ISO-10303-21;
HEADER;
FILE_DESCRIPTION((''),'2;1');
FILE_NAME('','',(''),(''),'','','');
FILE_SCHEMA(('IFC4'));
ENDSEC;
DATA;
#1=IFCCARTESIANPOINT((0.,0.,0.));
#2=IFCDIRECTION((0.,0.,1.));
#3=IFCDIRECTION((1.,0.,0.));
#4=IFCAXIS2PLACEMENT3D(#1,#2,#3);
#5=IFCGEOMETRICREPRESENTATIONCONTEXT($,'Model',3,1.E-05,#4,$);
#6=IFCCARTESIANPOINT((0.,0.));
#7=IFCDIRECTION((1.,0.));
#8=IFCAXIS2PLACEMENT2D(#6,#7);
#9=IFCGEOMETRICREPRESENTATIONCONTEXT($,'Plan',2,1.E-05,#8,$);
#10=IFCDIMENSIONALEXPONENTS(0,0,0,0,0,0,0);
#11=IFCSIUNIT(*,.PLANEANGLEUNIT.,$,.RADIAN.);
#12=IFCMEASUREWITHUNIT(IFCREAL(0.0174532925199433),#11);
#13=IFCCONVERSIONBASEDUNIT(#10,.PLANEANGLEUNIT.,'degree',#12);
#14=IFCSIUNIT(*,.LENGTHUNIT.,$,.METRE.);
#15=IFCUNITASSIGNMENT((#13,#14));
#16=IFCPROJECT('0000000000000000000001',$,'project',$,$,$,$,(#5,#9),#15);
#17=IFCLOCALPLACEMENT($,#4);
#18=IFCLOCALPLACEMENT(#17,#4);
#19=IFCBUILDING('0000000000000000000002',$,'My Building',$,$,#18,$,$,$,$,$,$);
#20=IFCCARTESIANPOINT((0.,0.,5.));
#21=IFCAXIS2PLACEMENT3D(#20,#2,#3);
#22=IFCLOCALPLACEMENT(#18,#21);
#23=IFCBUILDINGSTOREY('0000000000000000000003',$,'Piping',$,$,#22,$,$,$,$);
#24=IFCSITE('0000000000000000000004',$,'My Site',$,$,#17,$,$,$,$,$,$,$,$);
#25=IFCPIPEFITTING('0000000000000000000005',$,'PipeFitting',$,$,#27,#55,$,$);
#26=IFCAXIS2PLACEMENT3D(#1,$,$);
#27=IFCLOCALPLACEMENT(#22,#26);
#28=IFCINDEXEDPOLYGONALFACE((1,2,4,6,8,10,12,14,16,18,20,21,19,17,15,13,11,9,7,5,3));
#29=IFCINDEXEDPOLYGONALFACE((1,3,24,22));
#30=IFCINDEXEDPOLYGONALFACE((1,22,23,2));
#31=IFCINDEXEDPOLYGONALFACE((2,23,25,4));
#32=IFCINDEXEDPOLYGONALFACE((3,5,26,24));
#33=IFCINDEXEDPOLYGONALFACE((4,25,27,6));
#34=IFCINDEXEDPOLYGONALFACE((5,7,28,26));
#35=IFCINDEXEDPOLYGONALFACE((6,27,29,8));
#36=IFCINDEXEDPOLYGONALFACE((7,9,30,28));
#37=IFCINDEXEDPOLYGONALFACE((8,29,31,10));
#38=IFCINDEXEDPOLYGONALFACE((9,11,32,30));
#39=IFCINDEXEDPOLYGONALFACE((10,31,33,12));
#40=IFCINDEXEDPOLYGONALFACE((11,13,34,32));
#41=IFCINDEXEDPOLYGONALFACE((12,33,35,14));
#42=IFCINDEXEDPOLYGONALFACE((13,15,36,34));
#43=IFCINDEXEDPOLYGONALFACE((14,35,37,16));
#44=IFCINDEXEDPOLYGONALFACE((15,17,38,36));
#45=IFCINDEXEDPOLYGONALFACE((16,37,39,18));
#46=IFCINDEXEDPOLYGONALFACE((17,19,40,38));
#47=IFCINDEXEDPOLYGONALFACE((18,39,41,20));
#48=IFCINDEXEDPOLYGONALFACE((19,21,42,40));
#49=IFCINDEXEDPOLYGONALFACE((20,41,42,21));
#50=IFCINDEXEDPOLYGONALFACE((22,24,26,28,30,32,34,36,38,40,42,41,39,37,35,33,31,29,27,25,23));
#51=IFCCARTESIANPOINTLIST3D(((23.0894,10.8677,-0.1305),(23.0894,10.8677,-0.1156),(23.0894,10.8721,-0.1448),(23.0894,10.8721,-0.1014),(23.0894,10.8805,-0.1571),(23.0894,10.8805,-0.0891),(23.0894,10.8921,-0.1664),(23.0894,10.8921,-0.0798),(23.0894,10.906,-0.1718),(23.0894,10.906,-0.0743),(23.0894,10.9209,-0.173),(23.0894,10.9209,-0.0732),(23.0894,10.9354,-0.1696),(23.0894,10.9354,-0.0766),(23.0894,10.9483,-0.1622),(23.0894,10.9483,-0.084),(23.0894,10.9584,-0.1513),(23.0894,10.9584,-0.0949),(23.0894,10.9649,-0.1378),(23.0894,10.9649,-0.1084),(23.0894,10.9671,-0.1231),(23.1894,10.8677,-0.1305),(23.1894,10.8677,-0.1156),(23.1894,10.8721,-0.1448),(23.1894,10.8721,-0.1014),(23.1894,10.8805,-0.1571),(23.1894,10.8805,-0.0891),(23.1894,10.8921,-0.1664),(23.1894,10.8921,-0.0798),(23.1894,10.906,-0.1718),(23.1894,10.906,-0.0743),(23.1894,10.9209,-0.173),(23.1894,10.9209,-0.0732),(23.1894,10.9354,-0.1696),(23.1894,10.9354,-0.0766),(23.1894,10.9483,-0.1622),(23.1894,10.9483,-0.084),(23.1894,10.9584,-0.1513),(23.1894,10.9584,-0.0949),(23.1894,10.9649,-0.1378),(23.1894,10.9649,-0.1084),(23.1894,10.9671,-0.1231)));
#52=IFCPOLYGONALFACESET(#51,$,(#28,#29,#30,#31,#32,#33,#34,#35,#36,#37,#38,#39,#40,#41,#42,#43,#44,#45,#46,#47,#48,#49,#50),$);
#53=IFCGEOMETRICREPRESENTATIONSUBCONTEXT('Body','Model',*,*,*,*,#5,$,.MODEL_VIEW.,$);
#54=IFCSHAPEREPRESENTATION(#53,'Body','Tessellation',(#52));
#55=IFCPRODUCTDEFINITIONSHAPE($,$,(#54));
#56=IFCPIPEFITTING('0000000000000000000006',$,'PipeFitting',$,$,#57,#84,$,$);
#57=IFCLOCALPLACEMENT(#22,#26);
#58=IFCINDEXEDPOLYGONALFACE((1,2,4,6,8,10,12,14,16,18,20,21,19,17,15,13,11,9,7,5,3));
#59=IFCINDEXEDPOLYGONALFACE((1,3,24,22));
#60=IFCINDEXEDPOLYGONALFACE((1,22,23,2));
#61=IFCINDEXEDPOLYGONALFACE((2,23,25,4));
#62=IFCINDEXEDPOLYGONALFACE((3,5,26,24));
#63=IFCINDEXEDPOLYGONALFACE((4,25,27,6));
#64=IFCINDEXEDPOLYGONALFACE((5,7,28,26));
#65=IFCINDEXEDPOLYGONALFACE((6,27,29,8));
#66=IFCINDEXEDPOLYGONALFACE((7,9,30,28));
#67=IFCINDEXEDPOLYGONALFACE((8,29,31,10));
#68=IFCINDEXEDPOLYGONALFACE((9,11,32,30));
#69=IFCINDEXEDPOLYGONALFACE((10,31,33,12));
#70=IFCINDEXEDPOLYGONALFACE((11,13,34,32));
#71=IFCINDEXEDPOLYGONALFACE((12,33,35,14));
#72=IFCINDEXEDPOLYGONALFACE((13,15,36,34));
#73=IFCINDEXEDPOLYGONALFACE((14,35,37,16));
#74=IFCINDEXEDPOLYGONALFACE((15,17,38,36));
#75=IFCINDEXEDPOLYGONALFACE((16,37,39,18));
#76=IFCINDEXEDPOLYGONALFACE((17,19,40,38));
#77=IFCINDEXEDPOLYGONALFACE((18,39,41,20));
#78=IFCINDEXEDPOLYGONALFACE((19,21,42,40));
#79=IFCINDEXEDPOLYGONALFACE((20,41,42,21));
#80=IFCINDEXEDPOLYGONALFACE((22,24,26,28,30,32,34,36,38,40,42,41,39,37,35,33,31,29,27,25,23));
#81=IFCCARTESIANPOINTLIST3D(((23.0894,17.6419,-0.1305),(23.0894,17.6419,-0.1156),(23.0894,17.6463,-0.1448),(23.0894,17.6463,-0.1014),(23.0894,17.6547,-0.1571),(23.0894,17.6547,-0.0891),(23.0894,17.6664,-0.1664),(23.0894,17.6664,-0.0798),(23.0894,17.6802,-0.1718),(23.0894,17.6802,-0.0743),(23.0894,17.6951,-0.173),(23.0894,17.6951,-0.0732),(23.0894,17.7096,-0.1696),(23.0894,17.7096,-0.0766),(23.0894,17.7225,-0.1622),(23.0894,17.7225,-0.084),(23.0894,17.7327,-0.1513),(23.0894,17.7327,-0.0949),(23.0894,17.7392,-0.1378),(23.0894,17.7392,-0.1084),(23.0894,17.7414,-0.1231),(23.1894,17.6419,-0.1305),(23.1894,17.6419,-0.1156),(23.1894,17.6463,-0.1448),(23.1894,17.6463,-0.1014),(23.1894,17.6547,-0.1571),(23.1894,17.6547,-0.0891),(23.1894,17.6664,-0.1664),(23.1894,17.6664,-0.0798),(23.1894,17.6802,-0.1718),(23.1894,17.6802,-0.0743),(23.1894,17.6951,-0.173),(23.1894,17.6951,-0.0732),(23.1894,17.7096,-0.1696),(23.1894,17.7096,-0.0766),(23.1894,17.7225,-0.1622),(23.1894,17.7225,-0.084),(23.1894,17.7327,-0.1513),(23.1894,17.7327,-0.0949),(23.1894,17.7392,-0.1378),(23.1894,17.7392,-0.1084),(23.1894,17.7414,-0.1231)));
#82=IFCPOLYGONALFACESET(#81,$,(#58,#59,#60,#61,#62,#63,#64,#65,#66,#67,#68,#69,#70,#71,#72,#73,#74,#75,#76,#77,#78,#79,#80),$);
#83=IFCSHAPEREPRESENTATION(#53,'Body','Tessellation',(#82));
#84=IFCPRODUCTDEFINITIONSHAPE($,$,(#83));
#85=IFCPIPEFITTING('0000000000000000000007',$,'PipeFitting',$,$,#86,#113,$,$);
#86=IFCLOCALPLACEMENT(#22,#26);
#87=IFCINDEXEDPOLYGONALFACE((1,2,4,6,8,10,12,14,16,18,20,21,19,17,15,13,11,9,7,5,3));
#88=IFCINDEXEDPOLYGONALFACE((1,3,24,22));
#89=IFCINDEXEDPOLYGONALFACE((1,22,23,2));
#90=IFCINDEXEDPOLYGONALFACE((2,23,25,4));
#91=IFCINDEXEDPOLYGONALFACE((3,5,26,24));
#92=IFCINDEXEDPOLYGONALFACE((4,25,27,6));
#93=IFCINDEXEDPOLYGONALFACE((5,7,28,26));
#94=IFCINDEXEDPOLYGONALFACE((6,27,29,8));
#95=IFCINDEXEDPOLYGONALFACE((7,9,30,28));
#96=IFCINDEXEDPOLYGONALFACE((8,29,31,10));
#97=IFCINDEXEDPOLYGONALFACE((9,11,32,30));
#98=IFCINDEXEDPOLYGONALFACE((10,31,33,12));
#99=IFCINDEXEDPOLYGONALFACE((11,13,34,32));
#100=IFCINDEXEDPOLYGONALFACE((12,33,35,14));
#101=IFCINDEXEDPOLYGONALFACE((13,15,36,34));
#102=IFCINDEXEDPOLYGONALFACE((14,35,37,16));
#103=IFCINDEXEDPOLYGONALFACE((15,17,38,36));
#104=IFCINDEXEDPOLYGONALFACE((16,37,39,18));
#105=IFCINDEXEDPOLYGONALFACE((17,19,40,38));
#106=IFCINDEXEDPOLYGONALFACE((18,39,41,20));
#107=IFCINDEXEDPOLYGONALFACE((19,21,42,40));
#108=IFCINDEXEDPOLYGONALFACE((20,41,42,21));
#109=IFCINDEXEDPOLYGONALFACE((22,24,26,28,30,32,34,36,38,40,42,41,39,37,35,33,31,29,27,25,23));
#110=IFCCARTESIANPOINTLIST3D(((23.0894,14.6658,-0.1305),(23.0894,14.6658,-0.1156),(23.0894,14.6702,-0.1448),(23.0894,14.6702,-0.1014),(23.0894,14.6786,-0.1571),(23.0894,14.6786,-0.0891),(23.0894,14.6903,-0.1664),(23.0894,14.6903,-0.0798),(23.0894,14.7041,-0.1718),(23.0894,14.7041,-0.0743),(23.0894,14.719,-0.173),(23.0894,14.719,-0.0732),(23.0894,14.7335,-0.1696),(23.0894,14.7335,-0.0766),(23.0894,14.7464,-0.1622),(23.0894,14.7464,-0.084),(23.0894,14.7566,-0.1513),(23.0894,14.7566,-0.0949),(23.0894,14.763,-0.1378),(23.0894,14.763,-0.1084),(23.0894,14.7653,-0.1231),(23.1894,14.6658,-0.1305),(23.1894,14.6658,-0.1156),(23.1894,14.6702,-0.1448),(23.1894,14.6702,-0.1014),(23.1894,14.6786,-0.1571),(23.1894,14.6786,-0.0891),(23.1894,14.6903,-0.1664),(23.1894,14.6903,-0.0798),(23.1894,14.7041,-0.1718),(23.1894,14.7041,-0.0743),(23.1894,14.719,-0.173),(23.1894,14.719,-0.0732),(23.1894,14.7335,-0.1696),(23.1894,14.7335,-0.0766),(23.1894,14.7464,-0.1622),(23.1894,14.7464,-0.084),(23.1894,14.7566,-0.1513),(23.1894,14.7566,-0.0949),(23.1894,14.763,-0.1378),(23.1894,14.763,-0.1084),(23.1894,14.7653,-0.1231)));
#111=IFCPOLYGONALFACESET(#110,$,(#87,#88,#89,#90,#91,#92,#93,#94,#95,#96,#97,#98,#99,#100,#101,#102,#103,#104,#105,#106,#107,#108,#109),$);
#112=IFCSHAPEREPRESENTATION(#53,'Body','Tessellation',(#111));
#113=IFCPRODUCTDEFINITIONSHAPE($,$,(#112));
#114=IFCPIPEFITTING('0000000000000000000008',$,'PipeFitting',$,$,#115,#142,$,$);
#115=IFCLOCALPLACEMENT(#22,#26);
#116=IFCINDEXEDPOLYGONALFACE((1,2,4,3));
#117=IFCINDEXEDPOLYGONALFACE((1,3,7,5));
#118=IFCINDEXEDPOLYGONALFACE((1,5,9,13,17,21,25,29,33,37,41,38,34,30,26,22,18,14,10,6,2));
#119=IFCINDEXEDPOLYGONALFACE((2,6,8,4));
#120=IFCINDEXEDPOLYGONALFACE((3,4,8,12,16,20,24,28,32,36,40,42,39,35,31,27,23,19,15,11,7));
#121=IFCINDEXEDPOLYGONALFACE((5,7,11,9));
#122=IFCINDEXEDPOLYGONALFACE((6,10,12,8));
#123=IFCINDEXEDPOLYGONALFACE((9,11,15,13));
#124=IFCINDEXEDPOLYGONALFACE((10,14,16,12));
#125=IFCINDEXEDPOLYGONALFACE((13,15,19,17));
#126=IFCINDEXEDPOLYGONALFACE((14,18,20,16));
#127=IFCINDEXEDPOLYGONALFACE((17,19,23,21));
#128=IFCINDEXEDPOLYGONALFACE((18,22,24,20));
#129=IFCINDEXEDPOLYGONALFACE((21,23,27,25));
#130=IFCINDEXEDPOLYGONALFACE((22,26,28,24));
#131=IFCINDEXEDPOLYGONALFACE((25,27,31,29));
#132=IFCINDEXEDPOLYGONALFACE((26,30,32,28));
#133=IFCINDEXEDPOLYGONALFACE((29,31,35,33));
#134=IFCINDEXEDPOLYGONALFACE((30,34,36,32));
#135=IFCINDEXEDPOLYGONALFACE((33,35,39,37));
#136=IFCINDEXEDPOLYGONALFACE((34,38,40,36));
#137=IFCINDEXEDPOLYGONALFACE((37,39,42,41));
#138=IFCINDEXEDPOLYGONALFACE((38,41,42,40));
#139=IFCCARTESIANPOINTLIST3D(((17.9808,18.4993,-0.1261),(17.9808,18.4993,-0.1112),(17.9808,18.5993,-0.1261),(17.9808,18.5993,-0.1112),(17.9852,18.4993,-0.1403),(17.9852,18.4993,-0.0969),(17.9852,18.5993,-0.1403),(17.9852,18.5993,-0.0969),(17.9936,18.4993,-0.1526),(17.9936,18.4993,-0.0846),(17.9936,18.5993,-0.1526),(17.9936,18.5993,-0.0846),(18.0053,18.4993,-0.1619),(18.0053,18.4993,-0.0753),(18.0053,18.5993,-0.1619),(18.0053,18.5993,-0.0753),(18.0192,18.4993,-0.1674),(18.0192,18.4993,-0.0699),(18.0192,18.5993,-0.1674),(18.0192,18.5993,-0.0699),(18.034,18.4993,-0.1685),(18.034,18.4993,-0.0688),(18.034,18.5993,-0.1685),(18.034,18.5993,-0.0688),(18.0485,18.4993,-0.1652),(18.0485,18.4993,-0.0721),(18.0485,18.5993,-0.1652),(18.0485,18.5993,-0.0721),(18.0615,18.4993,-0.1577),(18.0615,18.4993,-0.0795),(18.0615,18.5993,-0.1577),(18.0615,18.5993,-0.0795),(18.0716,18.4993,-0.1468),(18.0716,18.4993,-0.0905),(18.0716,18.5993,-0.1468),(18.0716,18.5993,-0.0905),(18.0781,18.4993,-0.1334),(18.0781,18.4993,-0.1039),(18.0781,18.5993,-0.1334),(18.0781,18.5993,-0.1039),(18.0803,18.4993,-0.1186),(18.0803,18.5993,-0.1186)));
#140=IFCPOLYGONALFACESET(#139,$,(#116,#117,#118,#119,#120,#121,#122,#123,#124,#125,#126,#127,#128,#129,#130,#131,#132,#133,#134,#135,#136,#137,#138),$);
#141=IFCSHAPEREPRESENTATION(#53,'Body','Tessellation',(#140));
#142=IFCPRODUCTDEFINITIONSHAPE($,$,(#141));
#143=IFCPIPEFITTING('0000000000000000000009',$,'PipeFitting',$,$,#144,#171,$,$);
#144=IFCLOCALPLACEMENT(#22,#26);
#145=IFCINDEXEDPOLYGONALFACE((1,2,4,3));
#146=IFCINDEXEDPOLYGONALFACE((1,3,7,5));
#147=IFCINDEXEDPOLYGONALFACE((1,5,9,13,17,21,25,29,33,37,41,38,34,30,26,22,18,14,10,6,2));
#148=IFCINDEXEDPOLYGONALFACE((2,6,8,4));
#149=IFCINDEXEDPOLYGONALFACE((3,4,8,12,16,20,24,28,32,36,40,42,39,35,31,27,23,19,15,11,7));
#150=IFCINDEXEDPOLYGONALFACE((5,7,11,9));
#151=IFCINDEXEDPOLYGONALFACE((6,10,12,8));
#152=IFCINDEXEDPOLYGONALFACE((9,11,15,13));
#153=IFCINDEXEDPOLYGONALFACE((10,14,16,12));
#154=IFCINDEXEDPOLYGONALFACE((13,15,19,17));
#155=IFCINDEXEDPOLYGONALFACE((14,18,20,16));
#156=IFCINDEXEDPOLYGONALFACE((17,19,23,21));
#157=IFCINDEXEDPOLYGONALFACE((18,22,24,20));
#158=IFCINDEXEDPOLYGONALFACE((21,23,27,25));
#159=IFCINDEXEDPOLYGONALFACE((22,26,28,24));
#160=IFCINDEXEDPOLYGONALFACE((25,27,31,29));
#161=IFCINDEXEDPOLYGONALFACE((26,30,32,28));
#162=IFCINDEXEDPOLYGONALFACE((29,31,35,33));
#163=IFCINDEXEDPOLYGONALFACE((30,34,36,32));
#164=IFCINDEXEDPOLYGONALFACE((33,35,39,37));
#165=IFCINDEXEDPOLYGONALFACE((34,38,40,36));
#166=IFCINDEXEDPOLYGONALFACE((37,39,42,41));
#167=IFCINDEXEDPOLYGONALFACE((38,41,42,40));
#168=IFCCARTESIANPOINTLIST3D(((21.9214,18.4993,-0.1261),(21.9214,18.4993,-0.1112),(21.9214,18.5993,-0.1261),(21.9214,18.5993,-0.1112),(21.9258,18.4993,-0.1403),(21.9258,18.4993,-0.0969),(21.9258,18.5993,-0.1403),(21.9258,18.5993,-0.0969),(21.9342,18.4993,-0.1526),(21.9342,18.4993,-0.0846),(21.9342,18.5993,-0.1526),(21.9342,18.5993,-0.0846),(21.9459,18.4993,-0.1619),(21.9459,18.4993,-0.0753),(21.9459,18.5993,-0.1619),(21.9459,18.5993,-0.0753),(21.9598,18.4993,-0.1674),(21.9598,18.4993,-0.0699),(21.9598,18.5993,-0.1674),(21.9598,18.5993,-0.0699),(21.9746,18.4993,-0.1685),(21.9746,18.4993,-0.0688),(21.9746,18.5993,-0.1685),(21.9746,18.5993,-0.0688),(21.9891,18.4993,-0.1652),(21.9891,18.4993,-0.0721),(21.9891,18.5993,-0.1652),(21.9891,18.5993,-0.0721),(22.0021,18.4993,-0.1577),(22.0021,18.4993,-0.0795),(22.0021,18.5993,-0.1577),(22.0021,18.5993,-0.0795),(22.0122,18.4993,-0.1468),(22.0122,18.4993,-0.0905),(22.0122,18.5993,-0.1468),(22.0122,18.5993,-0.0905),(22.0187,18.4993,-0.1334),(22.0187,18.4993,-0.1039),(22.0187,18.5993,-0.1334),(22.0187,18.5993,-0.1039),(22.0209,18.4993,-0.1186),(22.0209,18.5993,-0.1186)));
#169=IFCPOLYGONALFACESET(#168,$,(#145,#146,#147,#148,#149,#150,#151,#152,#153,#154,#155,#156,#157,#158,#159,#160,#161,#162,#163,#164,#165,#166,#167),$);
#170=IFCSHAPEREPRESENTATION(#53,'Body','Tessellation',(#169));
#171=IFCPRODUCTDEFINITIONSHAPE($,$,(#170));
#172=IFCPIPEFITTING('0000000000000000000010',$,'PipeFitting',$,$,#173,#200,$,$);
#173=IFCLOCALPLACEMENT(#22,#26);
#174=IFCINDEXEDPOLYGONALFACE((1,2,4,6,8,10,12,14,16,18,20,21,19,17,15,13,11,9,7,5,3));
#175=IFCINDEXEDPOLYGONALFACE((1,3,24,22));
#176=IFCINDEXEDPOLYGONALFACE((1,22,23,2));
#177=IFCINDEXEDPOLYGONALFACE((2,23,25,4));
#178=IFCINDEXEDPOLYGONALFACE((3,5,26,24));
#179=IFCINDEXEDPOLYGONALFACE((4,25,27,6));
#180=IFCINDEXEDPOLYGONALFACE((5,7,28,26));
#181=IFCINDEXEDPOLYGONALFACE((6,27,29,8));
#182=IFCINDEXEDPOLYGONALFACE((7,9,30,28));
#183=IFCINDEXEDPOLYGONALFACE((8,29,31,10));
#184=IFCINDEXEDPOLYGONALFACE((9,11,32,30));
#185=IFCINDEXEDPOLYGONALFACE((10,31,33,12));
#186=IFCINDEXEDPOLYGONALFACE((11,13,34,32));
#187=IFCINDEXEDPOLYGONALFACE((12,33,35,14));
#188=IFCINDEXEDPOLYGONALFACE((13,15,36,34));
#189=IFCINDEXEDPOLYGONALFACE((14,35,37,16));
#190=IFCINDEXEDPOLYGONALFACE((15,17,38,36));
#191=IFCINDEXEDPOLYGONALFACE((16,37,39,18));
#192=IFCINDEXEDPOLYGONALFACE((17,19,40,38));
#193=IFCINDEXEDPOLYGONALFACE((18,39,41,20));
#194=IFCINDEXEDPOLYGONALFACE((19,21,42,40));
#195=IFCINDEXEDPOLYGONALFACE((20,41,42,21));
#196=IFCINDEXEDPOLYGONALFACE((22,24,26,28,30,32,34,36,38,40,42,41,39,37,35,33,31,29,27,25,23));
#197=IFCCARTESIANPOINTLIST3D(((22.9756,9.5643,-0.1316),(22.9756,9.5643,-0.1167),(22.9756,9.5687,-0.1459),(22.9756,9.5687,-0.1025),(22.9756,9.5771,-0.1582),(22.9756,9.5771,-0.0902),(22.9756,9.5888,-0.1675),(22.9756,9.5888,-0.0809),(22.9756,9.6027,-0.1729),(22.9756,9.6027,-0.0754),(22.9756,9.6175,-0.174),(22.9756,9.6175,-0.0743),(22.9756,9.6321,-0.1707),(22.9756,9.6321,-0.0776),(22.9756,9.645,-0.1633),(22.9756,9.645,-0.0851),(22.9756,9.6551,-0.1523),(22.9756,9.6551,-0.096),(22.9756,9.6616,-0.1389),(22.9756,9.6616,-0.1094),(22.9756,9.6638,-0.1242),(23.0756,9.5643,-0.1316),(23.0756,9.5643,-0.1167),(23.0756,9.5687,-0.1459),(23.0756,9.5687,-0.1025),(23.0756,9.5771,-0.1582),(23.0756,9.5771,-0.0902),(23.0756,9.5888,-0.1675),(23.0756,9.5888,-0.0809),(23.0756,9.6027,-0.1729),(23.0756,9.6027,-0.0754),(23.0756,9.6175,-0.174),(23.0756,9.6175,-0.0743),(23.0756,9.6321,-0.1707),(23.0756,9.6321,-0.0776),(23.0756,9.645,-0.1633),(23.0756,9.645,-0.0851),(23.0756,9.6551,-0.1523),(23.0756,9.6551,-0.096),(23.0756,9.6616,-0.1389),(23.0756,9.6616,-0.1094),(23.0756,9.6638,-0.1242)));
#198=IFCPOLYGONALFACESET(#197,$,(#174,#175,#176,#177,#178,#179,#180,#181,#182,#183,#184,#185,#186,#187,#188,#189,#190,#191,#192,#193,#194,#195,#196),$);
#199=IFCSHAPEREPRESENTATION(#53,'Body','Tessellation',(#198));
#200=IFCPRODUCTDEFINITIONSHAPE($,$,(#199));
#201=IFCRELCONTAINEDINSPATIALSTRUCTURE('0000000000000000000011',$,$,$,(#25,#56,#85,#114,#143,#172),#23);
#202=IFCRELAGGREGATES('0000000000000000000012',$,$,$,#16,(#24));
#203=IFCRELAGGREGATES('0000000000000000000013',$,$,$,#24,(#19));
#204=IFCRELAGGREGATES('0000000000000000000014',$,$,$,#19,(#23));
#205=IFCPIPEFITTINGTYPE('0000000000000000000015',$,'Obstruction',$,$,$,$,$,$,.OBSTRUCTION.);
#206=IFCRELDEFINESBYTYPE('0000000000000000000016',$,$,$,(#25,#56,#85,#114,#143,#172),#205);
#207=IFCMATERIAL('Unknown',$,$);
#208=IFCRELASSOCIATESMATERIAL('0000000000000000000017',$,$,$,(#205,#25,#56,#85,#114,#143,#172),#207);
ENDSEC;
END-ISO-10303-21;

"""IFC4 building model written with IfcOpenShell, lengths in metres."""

from ifc_helpers import new_model, entity, si_unit, converted_unit, frame, origin_with_axes, origin_2d_with_axis, place, context, subcontext, project, spatial, circle, extrude, material, material_profile, profile_set, profile_usage, type_object, element, save


model = new_model("IFC4")

# Units and contexts
model_context = context("Model", 3, precision=1e-05, world=origin_with_axes())
plan_context = context("Plan", 2, precision=1e-05, world=origin_2d_with_axis())
body_context = subcontext(model_context, "Body", "Model", "MODEL_VIEW")
ifc_project = project(units=[converted_unit("PLANEANGLEUNIT", "degree", entity("IfcReal", 0.0174532925199433), si_unit("PLANEANGLEUNIT", "RADIAN"), dimensions=[0, 0, 0, 0, 0, 0, 0]), si_unit("LENGTHUNIT", "METRE")], contexts=[model_context, plan_context])

# Site, building, storey
site_placement = place(None, origin_with_axes())
site = spatial("IfcSite", under=ifc_project, at=site_placement, Name="My Site")
building_placement = place(site_placement, origin_with_axes())
building = spatial("IfcBuilding", under=site, at=building_placement, Name="My Building")
storey_placement = place(building_placement, frame((0.0, 0.0, 5.0), z_axis=(0.0, 0.0, 1.0), x_axis=(1.0, 0.0, 0.0)))
storey = spatial("IfcBuildingStorey", under=building, at=storey_placement, Name="Piping")

# Shared definitions
ifc_material = material(Name="Unknown")

# Pipe fittings
ifc_material_profile_1 = material_profile(ifc_material, circle(Radius=0.05))
ifc_profile_set_1 = profile_set([ifc_material_profile_1])
ifc_profile_usage_1 = profile_usage(ifc_profile_set_1, cardinal=5)
pipe_fitting_type_1 = type_object("IfcPipeFittingType", Name="Obstruction", PredefinedType="OBSTRUCTION", material=ifc_profile_set_1)
pipe_fitting_1_placement = place(storey_placement, frame((23.0894, 10.9171, -0.1231), z_axis=(1.0, 0.0, 0.0), x_axis=(0.0, 1.0, 0.0)))
element("IfcPipeFitting", 1, at=pipe_fitting_1_placement, inside=storey, type_object=pipe_fitting_type_1, material=ifc_profile_usage_1, Name="PipeFitting", context=body_context, shape_type="SweptSolid", body=[
    extrude(circle(Radius=0.05), origin_with_axes(), (0.0, 0.0, 1.0), 0.1),
])
ifc_profile_usage_2 = profile_usage(ifc_profile_set_1, cardinal=5)
pipe_fitting_2_placement = place(storey_placement, frame((23.0894, 17.6914, -0.1231), z_axis=(1.0, 0.0, 0.0), x_axis=(0.0, 1.0, 0.0)))
element("IfcPipeFitting", 2, at=pipe_fitting_2_placement, inside=storey, type_object=pipe_fitting_type_1, material=ifc_profile_usage_2, Name="PipeFitting", context=body_context, shape_type="SweptSolid", body=[
    extrude(circle(Radius=0.05), origin_with_axes(), (0.0, 0.0, 1.0), 0.1),
])
ifc_profile_usage_3 = profile_usage(ifc_profile_set_1, cardinal=5)
pipe_fitting_3_placement = place(storey_placement, frame((23.0894, 14.7153, -0.1231), z_axis=(1.0, 0.0, 0.0), x_axis=(0.0, 1.0, 0.0)))
element("IfcPipeFitting", 3, at=pipe_fitting_3_placement, inside=storey, type_object=pipe_fitting_type_1, material=ifc_profile_usage_3, Name="PipeFitting", context=body_context, shape_type="SweptSolid", body=[
    extrude(circle(Radius=0.05), origin_with_axes(), (0.0, 0.0, 1.0), 0.1),
])
ifc_profile_usage_4 = profile_usage(ifc_profile_set_1, cardinal=5)
pipe_fitting_4_placement = place(storey_placement, frame((18.0303, 18.5993, -0.1186), z_axis=(0.0, -1.0, 0.0), x_axis=(1.0, 0.0, 0.0)))
element("IfcPipeFitting", 4, at=pipe_fitting_4_placement, inside=storey, type_object=pipe_fitting_type_1, material=ifc_profile_usage_4, Name="PipeFitting", context=body_context, shape_type="SweptSolid", body=[
    extrude(circle(Radius=0.05), origin_with_axes(), (0.0, 0.0, 1.0), 0.1),
])
ifc_profile_usage_5 = profile_usage(ifc_profile_set_1, cardinal=5)
pipe_fitting_5_placement = place(storey_placement, frame((21.9709, 18.5993, -0.1186), z_axis=(0.0, -1.0, 0.0), x_axis=(1.0, 0.0, 0.0)))
element("IfcPipeFitting", 5, at=pipe_fitting_5_placement, inside=storey, type_object=pipe_fitting_type_1, material=ifc_profile_usage_5, Name="PipeFitting", context=body_context, shape_type="SweptSolid", body=[
    extrude(circle(Radius=0.05), origin_with_axes(), (0.0, 0.0, 1.0), 0.1),
])
ifc_profile_usage_6 = profile_usage(ifc_profile_set_1, cardinal=5)
pipe_fitting_6_placement = place(storey_placement, frame((22.9756, 9.6138, -0.1242), z_axis=(1.0, 0.0, 0.0), x_axis=(0.0, 1.0, 0.0)))
element("IfcPipeFitting", 6, at=pipe_fitting_6_placement, inside=storey, type_object=pipe_fitting_type_1, material=ifc_profile_usage_6, Name="PipeFitting", context=body_context, shape_type="SweptSolid", body=[
    extrude(circle(Radius=0.05), origin_with_axes(), (0.0, 0.0, 1.0), 0.1),
])

save(model, "model.ifc")
